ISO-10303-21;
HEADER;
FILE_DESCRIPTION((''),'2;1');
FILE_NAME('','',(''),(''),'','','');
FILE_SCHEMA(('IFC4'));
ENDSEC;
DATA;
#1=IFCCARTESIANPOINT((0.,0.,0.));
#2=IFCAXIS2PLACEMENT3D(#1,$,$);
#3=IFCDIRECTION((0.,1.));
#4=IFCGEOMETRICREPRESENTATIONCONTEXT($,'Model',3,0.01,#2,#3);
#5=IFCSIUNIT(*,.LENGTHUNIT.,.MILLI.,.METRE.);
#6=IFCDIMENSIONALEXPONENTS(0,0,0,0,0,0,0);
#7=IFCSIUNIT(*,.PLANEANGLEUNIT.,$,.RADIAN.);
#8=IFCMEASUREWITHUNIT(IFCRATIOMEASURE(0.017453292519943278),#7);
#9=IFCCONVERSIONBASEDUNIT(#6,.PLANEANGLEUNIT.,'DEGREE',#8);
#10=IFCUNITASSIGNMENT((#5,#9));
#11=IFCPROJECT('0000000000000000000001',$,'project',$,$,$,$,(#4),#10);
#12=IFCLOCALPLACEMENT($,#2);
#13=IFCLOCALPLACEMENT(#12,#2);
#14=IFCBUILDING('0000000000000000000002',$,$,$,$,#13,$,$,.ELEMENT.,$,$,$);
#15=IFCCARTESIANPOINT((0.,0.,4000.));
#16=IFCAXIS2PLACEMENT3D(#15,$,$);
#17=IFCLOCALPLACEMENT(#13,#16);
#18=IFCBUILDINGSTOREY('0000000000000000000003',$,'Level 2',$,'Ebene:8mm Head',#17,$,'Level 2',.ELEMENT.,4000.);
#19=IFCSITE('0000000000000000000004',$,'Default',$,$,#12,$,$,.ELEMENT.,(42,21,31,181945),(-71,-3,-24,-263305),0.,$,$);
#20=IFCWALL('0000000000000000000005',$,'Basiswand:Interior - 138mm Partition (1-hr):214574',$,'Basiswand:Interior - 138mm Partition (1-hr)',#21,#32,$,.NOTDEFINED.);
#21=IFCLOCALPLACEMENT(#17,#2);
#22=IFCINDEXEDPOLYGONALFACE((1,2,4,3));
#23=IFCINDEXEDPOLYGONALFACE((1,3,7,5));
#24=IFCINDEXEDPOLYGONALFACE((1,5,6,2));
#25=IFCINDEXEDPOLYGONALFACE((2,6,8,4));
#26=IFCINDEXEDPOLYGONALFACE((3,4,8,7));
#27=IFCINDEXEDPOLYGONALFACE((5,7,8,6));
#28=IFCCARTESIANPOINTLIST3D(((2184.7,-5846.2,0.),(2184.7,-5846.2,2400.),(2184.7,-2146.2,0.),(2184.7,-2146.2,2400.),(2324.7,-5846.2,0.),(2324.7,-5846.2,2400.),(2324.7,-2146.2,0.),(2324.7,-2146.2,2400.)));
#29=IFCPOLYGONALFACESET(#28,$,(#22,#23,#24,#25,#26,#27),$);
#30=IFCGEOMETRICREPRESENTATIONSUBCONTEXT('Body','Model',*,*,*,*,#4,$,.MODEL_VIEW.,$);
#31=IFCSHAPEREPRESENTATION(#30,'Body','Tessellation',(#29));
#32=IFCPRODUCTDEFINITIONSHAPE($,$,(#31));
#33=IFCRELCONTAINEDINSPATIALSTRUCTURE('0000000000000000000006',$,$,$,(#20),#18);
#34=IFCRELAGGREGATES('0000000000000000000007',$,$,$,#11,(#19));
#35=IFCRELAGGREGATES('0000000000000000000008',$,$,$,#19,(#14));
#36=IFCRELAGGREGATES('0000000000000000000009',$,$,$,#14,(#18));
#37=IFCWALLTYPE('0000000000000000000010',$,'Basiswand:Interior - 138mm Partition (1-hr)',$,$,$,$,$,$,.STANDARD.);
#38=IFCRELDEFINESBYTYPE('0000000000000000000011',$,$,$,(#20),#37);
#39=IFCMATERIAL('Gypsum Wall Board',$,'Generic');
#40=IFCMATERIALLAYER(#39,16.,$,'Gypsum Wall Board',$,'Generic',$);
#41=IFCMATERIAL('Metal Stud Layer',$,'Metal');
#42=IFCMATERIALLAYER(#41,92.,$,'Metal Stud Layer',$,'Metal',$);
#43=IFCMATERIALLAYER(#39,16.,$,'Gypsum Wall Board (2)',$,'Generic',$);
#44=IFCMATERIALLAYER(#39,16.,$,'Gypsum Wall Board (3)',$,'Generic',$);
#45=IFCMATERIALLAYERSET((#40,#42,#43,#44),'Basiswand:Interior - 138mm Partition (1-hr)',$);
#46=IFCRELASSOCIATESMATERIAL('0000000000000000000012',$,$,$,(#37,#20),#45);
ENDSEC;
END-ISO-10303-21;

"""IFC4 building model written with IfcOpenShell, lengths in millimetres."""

from ifc_helpers import new_model, entity, si_unit, converted_unit, direction, frame, frame_2d, origin, place, context, subcontext, project, spatial, rectangle, extrude, material, layer, layer_set, layer_usage, type_object, element, save


model = new_model("IFC4")

# Units and contexts
model_context = context("Model", 3, precision=0.01, world=origin(), true_north=direction((0.0, 1.0)))
body_context = subcontext(model_context, "Body", "Model", "MODEL_VIEW")
ifc_project = project(units=[si_unit("LENGTHUNIT", "METRE", prefix="MILLI"), converted_unit("PLANEANGLEUNIT", "DEGREE", entity("IfcRatioMeasure", 0.017453292519943278), si_unit("PLANEANGLEUNIT", "RADIAN"), dimensions=[0, 0, 0, 0, 0, 0, 0])], contexts=[model_context])

# Site, building, storey
site_placement = place(None, origin())
site = spatial("IfcSite", under=ifc_project, at=site_placement, Name="Default", CompositionType="ELEMENT", RefLatitude=(42, 21, 31, 181945), RefLongitude=(-71, -3, -24, -263305), RefElevation=0.0)
building_placement = place(site_placement, origin())
building = spatial("IfcBuilding", under=site, at=building_placement, CompositionType="ELEMENT")
storey_placement = place(building_placement, frame((0.0, 0.0, 4000.0)))
storey = spatial("IfcBuildingStorey", under=building, at=storey_placement, Name="Level 2", ObjectType="Ebene:8mm Head", LongName="Level 2", CompositionType="ELEMENT", Elevation=4000.0)

# Shared definitions
ifc_material_1 = material(Name="Gypsum Wall Board", Category="Generic")
ifc_layer_1 = layer(ifc_material_1, 16.0, Name="Gypsum Wall Board", Category="Generic")
ifc_material_2 = material(Name="Metal Stud Layer", Category="Metal")
ifc_layer_2 = layer(ifc_material_2, 92.0, Name="Metal Stud Layer", Category="Metal")
ifc_layer_3 = layer(ifc_material_1, 16.0, Name="Gypsum Wall Board (2)", Category="Generic")
ifc_layer_4 = layer(ifc_material_1, 16.0, Name="Gypsum Wall Board (3)", Category="Generic")
ifc_layer_set_1 = layer_set([ifc_layer_1, ifc_layer_2, ifc_layer_3, ifc_layer_4], Name="Basiswand:Interior - 138mm Partition (1-hr)")
wall_type_1 = type_object("IfcWallType", Name="Basiswand:Interior - 138mm Partition (1-hr)", PredefinedType="STANDARD", material=ifc_layer_set_1)

# Wall
ifc_layer_usage_1 = layer_usage(ifc_layer_set_1, "AXIS2", "NEGATIVE", 70.0)
wall_1_placement = place(storey_placement, frame((2254.7, -2146.2, 0.0), z_axis=(0.0, 0.0, 1.0), x_axis=(0.0, -1.0, 0.0)))
element("IfcWall", 1, at=wall_1_placement, inside=storey, type_object=wall_type_1, material=ifc_layer_usage_1, Name="Basiswand:Interior - 138mm Partition (1-hr):214574", ObjectType="Basiswand:Interior - 138mm Partition (1-hr)", PredefinedType="NOTDEFINED", context=body_context, shape_type="SweptSolid", body=[
    extrude(rectangle(XDim=3700.0, YDim=140.0, at=frame_2d((1850.0, 0.0), x_axis=(-1.0, 0.0))), origin(), (0.0, 0.0, 1.0), 2400.0),
])

save(model, "model.ifc")
